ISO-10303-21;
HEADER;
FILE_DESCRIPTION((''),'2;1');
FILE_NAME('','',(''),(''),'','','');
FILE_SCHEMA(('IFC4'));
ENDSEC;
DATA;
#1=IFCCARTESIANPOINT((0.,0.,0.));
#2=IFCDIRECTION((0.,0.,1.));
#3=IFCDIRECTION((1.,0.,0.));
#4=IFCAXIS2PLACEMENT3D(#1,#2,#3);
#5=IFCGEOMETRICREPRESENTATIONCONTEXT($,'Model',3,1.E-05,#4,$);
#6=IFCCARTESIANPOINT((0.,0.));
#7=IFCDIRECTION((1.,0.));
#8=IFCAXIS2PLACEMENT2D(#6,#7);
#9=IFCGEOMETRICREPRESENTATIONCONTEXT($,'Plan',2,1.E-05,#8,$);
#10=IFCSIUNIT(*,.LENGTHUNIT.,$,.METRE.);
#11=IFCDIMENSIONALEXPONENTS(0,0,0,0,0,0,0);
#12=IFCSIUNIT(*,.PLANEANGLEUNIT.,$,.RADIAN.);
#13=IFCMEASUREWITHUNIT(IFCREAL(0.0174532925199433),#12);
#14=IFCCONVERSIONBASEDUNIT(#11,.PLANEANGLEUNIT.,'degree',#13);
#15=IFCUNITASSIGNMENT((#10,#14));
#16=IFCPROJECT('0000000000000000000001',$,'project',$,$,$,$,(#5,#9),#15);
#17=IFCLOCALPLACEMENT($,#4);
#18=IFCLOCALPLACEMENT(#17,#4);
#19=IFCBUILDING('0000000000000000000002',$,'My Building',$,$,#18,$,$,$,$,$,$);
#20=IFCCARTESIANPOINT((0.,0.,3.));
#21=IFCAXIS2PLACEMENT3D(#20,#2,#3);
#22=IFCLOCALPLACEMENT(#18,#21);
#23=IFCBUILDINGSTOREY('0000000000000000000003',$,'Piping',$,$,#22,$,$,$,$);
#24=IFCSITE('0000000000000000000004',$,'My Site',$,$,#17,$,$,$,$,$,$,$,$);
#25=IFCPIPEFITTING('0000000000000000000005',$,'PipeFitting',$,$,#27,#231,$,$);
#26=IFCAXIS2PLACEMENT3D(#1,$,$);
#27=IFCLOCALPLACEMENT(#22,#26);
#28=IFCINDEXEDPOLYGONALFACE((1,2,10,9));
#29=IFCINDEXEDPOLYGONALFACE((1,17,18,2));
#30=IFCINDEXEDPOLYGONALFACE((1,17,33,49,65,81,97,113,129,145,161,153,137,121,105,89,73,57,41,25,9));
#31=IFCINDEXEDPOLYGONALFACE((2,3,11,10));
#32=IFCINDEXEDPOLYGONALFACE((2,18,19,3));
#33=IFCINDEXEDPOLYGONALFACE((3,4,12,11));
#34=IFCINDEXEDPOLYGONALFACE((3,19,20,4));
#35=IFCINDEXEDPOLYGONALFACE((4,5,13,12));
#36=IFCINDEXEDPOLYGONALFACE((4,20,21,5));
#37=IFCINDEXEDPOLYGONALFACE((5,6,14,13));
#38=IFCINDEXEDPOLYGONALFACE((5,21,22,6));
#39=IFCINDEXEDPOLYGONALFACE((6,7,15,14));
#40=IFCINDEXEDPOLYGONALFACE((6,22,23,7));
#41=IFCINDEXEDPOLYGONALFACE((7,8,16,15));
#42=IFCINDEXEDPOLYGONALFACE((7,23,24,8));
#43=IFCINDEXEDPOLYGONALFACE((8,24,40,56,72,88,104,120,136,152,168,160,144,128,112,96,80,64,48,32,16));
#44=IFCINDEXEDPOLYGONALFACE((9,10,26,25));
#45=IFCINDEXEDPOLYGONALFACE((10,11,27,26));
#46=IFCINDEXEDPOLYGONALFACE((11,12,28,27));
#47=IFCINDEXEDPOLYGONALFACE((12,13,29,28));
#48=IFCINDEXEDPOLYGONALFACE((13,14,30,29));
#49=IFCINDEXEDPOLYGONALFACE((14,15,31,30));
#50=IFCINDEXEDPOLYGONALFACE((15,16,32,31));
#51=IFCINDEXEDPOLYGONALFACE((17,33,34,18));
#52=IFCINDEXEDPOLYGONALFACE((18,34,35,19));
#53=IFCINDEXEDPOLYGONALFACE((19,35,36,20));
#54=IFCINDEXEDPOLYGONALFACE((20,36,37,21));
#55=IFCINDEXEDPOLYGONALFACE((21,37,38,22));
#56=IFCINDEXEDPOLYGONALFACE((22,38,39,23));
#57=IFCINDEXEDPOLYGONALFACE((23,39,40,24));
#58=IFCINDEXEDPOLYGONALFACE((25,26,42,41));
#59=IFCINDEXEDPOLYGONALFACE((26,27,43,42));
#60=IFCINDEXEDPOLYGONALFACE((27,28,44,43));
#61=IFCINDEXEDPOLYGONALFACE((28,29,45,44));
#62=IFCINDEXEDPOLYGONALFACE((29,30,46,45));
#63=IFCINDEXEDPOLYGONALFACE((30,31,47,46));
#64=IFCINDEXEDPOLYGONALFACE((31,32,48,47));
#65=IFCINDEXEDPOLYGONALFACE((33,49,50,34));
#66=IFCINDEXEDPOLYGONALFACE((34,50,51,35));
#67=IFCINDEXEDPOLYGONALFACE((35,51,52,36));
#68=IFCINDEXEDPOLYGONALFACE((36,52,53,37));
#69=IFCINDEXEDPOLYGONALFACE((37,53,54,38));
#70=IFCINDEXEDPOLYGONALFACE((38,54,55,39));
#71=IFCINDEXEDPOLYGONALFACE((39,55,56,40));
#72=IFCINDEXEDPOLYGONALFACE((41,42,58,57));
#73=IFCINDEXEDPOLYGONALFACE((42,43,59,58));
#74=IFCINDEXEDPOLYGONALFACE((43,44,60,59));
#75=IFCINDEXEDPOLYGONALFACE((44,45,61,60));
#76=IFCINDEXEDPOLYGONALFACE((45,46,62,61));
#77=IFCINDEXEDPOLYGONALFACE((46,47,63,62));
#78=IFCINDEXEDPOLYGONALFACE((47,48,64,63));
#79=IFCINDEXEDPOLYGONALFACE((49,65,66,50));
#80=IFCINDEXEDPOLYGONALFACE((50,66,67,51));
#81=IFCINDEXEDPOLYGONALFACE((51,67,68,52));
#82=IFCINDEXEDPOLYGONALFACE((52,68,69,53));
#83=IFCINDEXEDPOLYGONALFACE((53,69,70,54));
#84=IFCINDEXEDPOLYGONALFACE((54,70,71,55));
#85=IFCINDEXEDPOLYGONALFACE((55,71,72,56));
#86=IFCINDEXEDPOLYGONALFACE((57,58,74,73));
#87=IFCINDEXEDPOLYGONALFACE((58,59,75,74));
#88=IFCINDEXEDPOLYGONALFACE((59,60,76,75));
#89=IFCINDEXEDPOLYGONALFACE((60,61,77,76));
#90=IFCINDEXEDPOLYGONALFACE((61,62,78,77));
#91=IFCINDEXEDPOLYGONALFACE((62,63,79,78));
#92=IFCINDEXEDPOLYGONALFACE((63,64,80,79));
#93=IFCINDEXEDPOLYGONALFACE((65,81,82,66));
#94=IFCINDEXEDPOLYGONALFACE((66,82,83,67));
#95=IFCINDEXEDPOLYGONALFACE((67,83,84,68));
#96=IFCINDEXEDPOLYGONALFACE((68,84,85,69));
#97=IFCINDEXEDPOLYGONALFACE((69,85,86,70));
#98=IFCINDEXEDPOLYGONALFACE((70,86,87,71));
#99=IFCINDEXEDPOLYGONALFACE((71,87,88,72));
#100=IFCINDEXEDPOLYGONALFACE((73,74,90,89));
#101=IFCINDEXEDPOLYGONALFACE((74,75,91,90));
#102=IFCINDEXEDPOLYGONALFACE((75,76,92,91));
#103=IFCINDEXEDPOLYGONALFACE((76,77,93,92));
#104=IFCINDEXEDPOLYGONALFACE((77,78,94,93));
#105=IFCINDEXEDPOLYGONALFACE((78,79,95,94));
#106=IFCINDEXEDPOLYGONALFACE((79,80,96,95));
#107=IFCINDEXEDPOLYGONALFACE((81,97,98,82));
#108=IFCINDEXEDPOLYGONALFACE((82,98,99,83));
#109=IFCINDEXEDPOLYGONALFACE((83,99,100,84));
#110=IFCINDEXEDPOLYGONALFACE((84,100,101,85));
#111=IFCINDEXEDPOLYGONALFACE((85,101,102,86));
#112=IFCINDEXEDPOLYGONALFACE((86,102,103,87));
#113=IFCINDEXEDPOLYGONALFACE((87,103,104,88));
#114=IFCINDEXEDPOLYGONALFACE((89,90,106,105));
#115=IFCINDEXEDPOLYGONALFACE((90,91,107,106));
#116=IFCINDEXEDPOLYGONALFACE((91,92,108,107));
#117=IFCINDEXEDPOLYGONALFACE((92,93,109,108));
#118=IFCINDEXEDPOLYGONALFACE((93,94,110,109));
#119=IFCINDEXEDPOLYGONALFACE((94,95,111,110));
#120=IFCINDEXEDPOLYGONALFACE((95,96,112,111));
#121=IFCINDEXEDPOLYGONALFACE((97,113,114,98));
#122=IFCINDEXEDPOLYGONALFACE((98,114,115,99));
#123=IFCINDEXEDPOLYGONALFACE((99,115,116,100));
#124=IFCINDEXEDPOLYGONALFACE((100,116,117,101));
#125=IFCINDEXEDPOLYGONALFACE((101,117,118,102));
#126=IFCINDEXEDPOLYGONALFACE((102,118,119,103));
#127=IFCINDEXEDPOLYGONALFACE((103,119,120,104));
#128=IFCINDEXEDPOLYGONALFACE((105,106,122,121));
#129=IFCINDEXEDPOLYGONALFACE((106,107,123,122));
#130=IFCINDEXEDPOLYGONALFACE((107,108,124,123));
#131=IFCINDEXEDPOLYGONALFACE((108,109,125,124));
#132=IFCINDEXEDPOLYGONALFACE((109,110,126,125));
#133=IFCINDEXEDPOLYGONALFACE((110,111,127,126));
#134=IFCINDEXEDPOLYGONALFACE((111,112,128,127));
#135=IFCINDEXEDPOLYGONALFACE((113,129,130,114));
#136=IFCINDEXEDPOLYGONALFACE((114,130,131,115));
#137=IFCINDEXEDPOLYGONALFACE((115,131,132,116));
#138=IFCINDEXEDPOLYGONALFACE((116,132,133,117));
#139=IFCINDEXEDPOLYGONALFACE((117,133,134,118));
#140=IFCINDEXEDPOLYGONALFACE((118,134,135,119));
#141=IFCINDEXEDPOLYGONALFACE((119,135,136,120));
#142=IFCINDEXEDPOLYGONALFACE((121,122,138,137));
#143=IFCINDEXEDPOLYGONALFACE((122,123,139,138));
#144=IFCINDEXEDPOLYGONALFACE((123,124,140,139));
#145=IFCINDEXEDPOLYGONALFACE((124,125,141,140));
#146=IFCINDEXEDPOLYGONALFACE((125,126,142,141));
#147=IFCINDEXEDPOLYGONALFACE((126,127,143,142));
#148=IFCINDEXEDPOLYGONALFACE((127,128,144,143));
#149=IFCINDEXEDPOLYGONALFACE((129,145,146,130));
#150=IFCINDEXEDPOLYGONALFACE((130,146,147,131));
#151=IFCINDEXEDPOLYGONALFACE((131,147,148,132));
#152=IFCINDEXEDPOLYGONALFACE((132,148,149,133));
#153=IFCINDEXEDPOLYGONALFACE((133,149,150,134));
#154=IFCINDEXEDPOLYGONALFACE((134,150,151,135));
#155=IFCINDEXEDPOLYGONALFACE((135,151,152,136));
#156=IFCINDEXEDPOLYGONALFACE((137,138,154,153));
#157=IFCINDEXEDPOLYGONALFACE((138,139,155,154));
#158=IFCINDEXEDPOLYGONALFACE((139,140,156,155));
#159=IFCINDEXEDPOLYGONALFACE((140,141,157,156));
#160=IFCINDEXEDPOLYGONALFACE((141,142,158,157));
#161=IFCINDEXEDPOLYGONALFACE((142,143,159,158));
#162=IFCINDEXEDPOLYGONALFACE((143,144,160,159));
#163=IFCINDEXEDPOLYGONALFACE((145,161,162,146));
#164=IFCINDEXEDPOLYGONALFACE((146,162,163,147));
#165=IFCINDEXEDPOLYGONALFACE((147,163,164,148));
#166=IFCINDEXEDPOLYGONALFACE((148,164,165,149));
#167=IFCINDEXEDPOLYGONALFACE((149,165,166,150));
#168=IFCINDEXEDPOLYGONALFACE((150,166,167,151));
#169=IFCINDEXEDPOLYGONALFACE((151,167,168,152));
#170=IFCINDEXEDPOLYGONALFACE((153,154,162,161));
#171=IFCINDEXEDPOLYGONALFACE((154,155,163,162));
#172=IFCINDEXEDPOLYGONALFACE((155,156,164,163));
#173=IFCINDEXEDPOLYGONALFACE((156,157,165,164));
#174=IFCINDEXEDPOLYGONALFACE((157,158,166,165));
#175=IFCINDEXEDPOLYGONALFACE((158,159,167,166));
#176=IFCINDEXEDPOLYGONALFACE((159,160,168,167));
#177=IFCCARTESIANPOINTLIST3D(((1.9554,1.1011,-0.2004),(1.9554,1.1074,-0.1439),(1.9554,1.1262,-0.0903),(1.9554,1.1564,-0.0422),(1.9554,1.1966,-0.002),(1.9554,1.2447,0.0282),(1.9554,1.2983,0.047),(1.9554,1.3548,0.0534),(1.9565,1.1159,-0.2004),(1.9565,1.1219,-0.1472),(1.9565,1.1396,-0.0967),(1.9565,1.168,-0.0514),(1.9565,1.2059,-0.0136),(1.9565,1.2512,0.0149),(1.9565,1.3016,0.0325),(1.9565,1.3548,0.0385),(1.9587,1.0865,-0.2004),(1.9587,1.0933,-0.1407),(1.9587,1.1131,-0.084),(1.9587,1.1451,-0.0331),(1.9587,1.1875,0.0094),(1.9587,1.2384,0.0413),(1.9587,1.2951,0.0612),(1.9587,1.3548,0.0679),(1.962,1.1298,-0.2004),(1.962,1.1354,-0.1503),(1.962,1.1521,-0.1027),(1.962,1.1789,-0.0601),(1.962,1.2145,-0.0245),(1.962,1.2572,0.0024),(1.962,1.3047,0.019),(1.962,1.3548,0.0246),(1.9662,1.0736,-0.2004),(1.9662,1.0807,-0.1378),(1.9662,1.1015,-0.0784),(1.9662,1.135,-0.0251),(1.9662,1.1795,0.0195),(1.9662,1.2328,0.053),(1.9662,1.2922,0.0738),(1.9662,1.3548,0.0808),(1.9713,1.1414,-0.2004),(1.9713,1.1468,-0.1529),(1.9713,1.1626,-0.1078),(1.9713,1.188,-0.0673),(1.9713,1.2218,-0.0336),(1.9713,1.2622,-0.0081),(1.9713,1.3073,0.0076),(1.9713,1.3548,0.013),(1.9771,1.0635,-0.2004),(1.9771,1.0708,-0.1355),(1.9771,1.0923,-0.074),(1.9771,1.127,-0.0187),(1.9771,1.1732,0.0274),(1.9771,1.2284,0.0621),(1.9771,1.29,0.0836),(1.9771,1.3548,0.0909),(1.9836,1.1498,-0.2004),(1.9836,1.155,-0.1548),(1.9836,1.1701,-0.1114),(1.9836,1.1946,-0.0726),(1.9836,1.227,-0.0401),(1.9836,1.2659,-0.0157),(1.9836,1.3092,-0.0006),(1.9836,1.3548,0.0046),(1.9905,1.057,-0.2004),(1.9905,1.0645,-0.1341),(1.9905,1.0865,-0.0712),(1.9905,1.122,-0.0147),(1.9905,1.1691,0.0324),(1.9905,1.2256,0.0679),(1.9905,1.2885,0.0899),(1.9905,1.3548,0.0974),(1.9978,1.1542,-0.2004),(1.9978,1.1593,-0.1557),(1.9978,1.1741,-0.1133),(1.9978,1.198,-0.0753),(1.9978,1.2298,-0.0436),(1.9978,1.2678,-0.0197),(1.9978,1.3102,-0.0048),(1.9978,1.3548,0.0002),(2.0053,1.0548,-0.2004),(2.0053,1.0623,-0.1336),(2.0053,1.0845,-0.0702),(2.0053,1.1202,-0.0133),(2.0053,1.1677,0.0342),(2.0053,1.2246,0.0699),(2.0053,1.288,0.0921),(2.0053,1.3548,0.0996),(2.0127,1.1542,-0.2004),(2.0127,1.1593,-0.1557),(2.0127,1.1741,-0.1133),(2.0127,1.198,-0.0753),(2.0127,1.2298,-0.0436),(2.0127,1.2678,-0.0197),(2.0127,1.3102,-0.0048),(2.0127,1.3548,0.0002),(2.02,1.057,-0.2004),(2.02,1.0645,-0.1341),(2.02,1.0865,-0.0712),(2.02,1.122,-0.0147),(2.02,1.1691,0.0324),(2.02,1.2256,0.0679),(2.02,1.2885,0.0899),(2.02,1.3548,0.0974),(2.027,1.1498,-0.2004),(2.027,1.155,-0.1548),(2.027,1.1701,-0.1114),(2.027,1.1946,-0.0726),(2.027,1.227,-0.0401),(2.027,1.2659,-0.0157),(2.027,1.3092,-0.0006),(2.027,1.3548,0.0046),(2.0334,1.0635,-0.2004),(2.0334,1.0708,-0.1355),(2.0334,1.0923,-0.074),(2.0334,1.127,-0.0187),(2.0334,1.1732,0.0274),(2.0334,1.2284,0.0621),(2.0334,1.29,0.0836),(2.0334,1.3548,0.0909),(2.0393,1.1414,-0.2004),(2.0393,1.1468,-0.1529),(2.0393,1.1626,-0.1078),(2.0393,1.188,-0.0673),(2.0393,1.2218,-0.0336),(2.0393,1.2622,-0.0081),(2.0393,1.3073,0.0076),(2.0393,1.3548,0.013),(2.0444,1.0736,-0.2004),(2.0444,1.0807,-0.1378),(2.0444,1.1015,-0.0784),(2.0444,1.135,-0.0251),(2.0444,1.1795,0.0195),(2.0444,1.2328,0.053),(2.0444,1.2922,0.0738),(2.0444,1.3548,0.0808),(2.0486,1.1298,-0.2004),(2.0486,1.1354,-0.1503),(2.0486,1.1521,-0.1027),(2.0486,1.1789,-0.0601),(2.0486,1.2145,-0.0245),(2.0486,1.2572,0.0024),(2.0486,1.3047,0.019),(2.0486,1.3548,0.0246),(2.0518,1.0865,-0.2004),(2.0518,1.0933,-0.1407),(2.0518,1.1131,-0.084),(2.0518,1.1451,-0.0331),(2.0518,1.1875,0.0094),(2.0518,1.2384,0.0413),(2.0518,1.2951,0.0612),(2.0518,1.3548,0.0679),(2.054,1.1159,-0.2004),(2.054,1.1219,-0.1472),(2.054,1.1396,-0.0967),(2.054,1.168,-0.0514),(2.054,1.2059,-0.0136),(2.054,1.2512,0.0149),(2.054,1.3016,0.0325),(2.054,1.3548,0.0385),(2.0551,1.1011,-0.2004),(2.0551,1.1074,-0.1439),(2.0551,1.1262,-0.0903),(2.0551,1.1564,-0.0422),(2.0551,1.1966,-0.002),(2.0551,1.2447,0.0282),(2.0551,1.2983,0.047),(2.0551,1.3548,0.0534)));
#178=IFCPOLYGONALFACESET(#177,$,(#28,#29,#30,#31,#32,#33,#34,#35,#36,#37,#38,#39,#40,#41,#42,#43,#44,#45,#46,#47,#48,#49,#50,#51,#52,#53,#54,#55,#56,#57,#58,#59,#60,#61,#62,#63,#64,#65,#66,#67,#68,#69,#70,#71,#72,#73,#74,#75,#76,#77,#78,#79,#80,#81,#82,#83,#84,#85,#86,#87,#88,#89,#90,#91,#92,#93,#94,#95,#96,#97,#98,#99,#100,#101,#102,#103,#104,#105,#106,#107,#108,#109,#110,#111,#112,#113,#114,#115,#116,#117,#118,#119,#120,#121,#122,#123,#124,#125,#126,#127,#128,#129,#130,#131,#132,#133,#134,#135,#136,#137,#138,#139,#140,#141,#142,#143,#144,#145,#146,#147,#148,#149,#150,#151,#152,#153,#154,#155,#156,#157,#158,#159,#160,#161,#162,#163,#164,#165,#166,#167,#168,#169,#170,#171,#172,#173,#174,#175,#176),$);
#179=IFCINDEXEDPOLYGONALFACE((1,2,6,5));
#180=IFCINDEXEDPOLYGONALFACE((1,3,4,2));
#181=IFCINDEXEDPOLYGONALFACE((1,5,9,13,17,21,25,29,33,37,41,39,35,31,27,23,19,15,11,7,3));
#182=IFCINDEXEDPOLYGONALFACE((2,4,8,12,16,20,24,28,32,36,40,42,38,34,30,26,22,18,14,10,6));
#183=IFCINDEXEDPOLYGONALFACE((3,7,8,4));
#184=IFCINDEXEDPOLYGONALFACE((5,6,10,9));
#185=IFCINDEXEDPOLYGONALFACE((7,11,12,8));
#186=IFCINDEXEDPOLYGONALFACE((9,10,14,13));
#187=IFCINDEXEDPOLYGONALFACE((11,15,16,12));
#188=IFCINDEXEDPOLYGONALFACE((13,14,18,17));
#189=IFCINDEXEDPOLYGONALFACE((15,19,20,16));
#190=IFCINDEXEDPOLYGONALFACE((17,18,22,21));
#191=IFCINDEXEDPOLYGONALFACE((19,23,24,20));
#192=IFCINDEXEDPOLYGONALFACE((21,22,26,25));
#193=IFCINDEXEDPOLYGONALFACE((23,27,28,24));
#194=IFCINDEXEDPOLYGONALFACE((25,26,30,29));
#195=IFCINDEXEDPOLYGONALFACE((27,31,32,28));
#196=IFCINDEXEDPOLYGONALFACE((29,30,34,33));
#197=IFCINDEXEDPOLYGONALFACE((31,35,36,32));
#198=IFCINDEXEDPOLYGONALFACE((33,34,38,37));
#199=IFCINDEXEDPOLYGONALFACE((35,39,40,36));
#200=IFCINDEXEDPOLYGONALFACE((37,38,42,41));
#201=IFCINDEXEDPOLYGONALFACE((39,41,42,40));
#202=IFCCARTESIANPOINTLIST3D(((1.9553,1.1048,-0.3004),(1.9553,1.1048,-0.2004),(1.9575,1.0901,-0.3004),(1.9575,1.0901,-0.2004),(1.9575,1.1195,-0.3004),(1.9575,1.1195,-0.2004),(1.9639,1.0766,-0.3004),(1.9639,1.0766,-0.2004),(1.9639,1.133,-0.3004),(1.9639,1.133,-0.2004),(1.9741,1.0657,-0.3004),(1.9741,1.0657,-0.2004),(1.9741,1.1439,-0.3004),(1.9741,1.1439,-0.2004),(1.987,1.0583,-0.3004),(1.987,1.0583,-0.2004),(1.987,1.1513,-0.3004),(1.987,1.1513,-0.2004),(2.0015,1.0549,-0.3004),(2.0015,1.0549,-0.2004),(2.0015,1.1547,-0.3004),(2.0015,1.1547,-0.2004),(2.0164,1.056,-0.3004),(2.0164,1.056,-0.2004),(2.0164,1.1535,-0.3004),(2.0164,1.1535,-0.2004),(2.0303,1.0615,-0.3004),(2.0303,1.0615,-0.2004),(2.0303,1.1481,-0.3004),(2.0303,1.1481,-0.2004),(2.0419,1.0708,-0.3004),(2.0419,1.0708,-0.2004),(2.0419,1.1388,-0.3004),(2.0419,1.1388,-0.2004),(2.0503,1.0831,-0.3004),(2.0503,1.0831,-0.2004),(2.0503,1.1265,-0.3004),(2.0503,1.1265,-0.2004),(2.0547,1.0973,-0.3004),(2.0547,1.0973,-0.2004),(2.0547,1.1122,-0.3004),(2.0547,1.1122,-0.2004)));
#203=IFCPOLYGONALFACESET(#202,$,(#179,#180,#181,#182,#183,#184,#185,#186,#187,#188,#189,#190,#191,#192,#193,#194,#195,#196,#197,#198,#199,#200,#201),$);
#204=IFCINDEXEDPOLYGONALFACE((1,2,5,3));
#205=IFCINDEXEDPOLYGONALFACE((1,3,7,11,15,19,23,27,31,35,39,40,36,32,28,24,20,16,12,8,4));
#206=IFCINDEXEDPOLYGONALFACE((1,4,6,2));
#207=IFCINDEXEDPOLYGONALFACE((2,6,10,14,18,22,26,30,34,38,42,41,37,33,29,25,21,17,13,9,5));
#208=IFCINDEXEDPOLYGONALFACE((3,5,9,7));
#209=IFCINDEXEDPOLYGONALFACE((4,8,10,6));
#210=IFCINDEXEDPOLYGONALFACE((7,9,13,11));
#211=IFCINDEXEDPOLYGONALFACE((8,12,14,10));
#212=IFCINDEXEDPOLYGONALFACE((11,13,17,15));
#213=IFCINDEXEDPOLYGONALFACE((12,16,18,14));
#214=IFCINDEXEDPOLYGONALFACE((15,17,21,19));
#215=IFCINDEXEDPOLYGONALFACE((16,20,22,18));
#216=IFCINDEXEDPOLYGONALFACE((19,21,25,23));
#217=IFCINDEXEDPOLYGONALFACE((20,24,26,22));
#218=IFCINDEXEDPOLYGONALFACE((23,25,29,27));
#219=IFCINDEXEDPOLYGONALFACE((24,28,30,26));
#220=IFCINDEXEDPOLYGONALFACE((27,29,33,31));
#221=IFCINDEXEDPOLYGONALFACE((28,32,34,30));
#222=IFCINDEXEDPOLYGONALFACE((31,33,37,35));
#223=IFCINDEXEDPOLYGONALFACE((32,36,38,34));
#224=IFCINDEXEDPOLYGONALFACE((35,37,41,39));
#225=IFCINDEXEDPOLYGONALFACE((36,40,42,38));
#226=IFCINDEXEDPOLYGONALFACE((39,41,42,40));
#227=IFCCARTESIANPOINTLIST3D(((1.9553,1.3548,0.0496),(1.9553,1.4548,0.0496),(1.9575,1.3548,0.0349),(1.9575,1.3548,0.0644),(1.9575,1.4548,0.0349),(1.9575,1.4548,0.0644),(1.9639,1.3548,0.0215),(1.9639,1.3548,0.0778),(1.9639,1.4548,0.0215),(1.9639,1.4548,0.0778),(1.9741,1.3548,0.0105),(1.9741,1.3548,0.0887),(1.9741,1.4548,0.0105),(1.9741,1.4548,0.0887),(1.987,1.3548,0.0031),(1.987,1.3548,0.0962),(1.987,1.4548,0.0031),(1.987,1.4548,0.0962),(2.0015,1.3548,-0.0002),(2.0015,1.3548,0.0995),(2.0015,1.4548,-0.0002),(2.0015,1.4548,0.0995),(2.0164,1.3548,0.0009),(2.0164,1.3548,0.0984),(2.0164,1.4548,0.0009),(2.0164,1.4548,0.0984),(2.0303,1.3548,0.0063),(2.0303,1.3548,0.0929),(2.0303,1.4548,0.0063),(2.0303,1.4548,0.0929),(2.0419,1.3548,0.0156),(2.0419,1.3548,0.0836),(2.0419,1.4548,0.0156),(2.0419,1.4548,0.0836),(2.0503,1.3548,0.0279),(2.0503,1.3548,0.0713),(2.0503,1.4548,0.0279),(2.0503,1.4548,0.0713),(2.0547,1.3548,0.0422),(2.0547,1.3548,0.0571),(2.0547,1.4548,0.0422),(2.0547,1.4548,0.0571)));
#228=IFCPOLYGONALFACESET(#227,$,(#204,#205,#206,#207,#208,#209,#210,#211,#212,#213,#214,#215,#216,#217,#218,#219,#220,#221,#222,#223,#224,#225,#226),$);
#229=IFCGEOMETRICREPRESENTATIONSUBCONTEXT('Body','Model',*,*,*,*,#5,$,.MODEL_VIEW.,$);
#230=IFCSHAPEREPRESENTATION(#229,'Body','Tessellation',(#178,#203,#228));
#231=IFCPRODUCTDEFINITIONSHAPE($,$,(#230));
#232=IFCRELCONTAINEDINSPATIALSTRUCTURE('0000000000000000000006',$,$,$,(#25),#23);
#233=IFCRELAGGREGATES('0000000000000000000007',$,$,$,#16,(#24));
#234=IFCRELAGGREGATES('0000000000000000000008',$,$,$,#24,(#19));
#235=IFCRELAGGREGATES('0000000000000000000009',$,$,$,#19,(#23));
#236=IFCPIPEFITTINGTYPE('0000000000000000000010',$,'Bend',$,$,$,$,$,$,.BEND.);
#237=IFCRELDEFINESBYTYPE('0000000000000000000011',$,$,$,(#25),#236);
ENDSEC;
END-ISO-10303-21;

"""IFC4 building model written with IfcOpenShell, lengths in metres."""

from ifc_helpers import new_model, entity, si_unit, converted_unit, frame, origin_with_axes, origin_2d_with_axis, place, context, subcontext, project, spatial, circle, extrude, source, transform, mapped, type_object, type_shapes, element, save


model = new_model("IFC4")

# Units and contexts
model_context = context("Model", 3, precision=1e-05, world=origin_with_axes())
plan_context = context("Plan", 2, precision=1e-05, world=origin_2d_with_axis())
body_context = subcontext(model_context, "Body", "Model", "MODEL_VIEW")
ifc_project = project(units=[si_unit("LENGTHUNIT", "METRE"), converted_unit("PLANEANGLEUNIT", "degree", entity("IfcReal", 0.0174532925199433), si_unit("PLANEANGLEUNIT", "RADIAN"), dimensions=[0, 0, 0, 0, 0, 0, 0])], contexts=[model_context, plan_context])

# Site, building, storey
site_placement = place(None, origin_with_axes())
site = spatial("IfcSite", under=ifc_project, at=site_placement, Name="My Site")
building_placement = place(site_placement, origin_with_axes())
building = spatial("IfcBuilding", under=site, at=building_placement, Name="My Building")
storey_placement = place(building_placement, frame((0.0, 0.0, 3.0), z_axis=(0.0, 0.0, 1.0), x_axis=(1.0, 0.0, 0.0)))
storey = spatial("IfcBuildingStorey", under=building, at=storey_placement, Name="Piping")

# Pipe fitting
pipe_fitting_type = type_object("IfcPipeFittingType", Name="Bend", PredefinedType="BEND")
shared_shape = source(origin_with_axes(), body_context, "Body", "SolidModel", [
    entity("IfcSweptDiskSolid", entity("IfcIndexedPolyCurve", entity("IfcCartesianPointList3D", [[0.0, 0.0, -0.1], [0.0, 0.0732, -0.2768], [0.0, 0.25, -0.35]]), [entity("IfcArcIndex", [1, 2, 3])]), 0.05),
    extrude(circle(Radius=0.05), origin_with_axes(), (0.0, 0.0, -1.0), 0.1),
    extrude(circle(Radius=0.05), frame((0.0, 0.25, -0.35), z_axis=(0.0, 1.0, 0.000007), x_axis=(1.0, 0.0, 0.0)), (0.0, 0.0, 1.0), 0.1),
])
type_shapes(pipe_fitting_type, [shared_shape])
for number, where, z_axis, x_axis, name in (
    (1, (2.0053, 1.1048, -0.3004), (0.0, 0.0, -1.0), (-1.0, 0.0, 0.0), "PipeFitting"),
):
    element("IfcPipeFitting", number, at=place(storey_placement, frame(where, z_axis=z_axis, x_axis=x_axis)), inside=storey, type_object=pipe_fitting_type, Name=name, context=body_context, shape_type="MappedRepresentation", body=[
        mapped(shared_shape, transform((0.0, 0.0, 0.0), x_axis=(1.0, 0.0, 0.0), y_axis=(0.0, 1.0, 0.0), z_axis=(0.0, 0.0, 1.0), scale=1.0)),
    ])

save(model, "model.ifc")
